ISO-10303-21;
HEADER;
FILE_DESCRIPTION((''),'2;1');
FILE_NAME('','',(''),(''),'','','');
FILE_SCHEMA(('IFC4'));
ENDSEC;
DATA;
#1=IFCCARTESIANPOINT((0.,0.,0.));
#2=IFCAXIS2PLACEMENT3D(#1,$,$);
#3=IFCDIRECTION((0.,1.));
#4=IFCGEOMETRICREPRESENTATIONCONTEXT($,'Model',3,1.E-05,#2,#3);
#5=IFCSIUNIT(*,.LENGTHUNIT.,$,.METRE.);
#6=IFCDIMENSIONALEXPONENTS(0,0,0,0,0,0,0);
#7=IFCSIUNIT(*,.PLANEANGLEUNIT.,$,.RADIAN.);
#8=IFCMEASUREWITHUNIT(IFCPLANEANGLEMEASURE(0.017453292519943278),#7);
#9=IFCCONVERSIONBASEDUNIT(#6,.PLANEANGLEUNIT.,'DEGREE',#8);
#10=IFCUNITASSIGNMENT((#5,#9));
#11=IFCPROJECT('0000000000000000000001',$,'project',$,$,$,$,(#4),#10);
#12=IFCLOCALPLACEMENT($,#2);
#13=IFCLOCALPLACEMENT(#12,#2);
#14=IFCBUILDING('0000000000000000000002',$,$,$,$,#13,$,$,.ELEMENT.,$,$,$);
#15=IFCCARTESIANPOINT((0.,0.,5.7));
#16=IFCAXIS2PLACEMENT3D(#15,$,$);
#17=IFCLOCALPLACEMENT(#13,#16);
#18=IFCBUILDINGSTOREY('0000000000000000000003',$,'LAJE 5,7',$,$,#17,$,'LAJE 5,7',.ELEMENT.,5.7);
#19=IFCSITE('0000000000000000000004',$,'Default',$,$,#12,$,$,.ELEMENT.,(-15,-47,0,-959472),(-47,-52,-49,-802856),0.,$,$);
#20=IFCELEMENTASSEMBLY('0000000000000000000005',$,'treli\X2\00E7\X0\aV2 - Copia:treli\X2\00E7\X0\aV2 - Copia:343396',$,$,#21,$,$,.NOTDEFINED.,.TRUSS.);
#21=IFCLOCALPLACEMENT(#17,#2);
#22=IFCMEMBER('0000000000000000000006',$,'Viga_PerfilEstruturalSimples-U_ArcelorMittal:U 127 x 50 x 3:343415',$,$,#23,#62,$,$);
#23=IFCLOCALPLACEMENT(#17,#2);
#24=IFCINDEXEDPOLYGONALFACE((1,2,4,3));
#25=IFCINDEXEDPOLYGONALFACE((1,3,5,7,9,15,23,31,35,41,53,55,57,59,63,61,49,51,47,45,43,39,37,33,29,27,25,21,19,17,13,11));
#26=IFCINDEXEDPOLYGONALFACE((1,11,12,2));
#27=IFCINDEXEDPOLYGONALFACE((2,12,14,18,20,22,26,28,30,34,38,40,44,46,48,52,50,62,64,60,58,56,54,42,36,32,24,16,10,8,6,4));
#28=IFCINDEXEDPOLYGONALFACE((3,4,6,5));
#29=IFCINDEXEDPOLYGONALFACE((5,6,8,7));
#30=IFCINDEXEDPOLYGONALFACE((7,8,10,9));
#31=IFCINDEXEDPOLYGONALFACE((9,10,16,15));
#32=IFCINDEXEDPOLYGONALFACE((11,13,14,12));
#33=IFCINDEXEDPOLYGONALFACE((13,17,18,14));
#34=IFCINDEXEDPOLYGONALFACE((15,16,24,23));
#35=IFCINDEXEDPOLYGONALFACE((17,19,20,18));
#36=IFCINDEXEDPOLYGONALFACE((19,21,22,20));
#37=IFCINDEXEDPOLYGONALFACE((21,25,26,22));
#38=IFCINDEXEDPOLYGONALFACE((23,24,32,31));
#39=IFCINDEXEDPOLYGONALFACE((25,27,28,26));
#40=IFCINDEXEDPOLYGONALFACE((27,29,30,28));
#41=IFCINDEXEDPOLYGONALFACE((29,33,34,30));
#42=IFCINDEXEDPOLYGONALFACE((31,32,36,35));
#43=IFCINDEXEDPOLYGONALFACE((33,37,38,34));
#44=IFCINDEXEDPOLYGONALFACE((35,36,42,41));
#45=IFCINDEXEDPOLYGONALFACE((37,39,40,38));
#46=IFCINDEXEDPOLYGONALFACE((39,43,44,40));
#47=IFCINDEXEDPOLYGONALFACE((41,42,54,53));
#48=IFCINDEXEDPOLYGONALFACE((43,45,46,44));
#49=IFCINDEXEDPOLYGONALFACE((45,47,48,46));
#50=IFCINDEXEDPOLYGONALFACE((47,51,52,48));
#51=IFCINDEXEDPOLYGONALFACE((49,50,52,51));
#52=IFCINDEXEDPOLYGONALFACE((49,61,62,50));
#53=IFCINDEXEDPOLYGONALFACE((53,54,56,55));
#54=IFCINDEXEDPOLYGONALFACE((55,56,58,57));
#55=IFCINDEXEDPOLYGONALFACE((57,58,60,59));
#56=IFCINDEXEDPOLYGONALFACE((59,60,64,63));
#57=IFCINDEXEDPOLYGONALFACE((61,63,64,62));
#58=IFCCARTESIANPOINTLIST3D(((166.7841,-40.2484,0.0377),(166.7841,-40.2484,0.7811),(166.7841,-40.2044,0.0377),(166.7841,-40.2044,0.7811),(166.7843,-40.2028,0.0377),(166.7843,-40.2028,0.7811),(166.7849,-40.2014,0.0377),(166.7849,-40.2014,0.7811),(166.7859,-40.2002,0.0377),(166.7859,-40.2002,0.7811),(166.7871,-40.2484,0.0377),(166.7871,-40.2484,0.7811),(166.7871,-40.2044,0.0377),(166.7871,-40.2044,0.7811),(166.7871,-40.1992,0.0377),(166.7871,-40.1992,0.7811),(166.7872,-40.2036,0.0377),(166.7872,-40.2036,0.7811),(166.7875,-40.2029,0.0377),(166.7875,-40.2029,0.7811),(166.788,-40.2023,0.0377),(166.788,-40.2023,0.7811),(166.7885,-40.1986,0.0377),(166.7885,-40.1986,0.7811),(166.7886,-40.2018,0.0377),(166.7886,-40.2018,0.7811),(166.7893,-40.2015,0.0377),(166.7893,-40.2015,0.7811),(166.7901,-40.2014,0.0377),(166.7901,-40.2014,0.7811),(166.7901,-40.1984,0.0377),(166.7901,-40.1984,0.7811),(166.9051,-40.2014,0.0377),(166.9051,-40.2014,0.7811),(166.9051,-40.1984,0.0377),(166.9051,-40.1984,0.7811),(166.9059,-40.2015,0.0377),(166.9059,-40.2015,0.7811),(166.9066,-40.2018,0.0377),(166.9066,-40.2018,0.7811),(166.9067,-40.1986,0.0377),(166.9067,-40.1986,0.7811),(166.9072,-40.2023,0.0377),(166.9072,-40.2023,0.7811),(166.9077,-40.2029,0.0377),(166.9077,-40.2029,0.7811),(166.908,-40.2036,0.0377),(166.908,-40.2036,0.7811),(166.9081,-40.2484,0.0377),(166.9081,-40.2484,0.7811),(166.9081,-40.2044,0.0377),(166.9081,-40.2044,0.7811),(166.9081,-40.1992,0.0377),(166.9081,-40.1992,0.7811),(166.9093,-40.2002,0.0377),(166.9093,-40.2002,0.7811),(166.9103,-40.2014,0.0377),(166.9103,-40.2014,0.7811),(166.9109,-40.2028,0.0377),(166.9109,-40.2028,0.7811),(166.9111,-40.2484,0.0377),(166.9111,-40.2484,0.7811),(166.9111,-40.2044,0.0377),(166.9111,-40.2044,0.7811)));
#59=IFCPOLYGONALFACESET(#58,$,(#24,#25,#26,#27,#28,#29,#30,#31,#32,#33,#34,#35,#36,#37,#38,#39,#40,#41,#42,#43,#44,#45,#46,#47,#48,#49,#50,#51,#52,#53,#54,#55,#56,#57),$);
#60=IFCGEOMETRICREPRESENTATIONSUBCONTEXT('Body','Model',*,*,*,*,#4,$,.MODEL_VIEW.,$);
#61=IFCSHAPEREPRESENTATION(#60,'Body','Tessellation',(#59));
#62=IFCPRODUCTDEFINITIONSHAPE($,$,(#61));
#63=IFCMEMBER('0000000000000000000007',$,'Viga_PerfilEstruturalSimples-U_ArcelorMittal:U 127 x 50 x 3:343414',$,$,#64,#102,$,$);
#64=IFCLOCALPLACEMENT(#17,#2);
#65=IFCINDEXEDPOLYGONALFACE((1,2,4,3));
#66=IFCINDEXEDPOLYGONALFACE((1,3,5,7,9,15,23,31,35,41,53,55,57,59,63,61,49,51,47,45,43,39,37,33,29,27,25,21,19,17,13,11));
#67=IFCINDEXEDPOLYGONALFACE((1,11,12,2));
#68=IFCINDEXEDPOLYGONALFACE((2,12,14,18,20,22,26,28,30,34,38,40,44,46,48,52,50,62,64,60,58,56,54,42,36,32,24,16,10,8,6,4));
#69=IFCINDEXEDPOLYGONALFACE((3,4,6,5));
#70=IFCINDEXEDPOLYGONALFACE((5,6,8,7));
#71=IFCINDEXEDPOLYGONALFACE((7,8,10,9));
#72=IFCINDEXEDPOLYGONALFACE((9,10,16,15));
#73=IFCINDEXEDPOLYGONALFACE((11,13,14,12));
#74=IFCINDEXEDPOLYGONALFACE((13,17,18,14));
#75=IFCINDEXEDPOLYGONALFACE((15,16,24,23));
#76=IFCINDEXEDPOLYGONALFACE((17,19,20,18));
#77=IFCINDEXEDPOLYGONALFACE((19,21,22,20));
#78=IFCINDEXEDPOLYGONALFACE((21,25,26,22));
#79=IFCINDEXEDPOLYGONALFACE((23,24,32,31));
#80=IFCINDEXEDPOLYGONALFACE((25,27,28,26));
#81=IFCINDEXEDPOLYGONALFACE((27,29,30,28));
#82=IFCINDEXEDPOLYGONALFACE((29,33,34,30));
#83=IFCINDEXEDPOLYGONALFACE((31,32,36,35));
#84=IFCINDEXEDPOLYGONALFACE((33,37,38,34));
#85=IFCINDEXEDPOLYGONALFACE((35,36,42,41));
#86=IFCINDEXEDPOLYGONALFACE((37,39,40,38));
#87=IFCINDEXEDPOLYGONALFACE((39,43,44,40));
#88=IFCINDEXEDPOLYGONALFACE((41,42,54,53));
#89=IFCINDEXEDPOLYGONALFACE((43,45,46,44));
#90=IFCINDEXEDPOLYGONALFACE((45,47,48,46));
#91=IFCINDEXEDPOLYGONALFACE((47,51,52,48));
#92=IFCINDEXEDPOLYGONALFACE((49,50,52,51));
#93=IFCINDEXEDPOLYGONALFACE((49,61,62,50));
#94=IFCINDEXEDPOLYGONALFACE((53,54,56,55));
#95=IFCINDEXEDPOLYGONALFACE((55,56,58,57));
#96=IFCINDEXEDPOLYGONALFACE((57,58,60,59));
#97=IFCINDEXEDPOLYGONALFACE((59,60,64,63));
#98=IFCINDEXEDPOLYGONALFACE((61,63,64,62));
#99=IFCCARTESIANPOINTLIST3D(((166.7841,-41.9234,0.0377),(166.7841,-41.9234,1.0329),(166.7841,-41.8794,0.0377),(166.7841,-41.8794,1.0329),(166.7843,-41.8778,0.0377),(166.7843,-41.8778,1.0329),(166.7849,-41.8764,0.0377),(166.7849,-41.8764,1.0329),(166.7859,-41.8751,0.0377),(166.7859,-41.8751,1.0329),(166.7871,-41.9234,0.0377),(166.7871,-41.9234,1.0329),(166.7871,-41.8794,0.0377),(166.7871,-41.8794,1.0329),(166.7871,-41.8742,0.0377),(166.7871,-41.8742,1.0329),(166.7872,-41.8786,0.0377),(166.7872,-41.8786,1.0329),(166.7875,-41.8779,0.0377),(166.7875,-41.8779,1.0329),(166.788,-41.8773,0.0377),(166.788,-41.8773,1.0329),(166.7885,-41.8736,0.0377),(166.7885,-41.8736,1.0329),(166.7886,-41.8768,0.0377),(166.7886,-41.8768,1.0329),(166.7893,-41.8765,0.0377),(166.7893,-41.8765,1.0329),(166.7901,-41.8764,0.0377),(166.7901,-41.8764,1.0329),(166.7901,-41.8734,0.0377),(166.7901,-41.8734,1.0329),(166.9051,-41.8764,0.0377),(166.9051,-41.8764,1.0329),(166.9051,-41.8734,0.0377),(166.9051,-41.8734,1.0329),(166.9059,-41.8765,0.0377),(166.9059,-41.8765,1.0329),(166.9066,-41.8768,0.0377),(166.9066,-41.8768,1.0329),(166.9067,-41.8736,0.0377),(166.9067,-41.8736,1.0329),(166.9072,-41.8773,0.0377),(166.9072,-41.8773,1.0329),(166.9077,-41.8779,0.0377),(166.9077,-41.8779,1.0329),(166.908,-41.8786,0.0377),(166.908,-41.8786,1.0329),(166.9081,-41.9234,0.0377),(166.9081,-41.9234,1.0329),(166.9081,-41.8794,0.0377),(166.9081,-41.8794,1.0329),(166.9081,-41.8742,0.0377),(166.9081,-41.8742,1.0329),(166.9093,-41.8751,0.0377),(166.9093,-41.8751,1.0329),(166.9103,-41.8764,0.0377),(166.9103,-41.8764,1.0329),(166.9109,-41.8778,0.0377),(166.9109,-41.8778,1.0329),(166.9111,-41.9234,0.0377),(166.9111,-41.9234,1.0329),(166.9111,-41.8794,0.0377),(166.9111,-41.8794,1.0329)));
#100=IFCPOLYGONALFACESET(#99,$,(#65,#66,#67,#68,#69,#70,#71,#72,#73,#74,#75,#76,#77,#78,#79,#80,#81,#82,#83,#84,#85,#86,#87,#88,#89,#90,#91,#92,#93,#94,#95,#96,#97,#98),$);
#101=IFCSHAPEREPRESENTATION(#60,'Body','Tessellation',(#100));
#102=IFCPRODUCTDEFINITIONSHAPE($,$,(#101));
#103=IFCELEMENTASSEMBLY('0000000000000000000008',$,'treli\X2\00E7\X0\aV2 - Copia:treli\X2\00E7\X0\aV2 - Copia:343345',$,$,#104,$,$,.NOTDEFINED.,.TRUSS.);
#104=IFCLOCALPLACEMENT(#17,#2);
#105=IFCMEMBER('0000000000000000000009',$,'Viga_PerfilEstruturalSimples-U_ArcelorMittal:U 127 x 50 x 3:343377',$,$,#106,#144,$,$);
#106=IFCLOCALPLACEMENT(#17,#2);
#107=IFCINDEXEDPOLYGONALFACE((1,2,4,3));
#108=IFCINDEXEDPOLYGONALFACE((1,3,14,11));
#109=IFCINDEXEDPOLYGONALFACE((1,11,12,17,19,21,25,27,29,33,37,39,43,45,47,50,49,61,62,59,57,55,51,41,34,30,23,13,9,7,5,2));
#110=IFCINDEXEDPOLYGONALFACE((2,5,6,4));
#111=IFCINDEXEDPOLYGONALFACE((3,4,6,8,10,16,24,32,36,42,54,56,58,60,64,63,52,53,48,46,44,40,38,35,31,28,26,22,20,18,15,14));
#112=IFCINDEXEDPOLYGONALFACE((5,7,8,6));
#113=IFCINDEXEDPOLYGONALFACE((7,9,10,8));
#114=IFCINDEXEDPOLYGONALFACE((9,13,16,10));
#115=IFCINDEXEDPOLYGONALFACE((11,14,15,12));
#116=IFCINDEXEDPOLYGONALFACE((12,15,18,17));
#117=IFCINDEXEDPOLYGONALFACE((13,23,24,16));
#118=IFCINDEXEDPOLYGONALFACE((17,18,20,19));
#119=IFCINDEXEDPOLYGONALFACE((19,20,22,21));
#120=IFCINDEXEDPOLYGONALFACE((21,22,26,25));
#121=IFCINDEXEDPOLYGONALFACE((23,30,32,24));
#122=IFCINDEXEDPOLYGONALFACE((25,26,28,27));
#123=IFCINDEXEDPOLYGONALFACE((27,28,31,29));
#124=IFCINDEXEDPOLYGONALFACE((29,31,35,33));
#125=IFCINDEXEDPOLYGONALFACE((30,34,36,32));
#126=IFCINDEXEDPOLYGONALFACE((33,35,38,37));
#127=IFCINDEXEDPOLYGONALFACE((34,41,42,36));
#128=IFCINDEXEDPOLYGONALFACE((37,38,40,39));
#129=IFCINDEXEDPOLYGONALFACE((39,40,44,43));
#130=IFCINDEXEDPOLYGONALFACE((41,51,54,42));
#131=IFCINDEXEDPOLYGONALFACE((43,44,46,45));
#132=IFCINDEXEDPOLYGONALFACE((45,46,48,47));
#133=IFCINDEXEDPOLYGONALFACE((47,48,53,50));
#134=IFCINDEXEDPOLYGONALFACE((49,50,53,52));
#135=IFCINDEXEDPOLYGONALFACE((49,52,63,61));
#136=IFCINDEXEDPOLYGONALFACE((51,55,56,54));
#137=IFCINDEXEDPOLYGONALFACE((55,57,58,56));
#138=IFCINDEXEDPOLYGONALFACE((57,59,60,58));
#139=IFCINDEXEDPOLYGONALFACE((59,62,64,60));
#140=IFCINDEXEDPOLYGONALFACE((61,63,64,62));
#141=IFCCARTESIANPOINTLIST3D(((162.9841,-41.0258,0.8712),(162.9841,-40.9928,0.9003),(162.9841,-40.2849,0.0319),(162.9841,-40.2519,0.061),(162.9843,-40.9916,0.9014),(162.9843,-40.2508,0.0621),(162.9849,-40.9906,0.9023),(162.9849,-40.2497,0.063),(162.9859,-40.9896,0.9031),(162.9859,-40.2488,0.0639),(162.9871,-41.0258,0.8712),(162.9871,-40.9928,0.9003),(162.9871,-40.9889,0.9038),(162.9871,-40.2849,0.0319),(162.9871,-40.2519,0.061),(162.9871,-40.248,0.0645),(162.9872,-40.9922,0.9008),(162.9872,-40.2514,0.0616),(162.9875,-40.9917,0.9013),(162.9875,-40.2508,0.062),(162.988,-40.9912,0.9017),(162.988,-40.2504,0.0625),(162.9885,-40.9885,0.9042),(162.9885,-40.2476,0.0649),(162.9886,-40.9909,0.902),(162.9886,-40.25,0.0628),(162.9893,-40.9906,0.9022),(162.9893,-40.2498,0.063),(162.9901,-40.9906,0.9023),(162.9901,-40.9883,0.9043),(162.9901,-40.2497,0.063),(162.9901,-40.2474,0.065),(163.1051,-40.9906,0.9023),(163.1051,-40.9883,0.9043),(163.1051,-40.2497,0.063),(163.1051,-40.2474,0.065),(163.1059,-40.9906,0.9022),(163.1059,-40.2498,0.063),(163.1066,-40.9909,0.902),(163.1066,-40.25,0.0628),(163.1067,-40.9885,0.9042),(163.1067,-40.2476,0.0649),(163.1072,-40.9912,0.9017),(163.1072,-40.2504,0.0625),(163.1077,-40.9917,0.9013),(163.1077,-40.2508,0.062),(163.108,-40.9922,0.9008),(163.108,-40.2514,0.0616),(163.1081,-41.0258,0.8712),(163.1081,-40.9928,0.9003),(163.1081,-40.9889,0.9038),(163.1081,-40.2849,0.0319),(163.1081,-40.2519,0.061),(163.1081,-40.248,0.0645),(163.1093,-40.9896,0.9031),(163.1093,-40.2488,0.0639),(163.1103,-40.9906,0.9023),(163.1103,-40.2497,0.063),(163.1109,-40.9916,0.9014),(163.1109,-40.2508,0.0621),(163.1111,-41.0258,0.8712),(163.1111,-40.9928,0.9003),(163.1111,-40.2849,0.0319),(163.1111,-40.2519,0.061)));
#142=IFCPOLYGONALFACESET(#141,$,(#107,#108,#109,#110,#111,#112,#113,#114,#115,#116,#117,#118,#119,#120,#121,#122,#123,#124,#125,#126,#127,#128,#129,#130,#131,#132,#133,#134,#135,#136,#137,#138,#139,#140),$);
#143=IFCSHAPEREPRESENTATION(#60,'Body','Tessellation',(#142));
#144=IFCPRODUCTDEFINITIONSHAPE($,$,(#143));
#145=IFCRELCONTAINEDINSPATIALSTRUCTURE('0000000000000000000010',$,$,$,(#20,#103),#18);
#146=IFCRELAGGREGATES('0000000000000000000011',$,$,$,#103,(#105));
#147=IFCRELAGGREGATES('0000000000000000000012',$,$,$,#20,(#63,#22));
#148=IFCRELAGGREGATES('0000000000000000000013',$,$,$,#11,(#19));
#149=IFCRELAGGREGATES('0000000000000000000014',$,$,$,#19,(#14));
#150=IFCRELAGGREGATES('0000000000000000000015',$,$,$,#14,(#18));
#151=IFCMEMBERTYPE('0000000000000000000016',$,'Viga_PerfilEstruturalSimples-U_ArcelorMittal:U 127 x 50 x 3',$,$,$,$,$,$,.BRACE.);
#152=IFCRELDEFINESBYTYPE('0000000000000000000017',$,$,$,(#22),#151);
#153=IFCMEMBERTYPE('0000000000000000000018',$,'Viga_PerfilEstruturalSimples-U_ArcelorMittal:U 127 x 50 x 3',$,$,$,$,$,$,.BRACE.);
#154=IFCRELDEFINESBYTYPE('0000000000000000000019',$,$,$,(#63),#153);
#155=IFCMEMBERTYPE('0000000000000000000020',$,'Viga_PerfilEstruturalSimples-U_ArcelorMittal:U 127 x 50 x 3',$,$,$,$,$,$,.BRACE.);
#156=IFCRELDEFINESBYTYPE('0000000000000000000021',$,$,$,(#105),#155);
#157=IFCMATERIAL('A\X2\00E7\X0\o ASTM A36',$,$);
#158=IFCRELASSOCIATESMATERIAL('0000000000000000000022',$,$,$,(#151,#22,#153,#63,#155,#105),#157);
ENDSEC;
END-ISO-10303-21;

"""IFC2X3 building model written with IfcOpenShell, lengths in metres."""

from ifc_helpers import new_model, entity, si_unit, converted_unit, direction, frame, frame_2d, origin, place, context, subcontext, project, spatial, polyline, circle_curve, parameter, trimmed, segment, composite_curve, outline, extrude, source, transform, mapped, material, type_object, type_shapes, element, aggregate, save


model = new_model("IFC2X3")

# Units and contexts
model_context = context("Model", 3, precision=1e-05, world=origin(), true_north=direction((0.0, 1.0)))
body_context = subcontext(model_context, "Body", "Model", "MODEL_VIEW")
ifc_project = project(units=[si_unit("LENGTHUNIT", "METRE"), converted_unit("PLANEANGLEUNIT", "DEGREE", entity("IfcPlaneAngleMeasure", 0.017453292519943278), si_unit("PLANEANGLEUNIT", "RADIAN"), dimensions=[0, 0, 0, 0, 0, 0, 0])], contexts=[model_context])

# Site, building, storey
site_placement = place(None, origin())
site = spatial("IfcSite", under=ifc_project, at=site_placement, Name="Default", CompositionType="ELEMENT", RefLatitude=(-15, -47, 0, -959472), RefLongitude=(-47, -52, -49, -802856), RefElevation=0.0)
building_placement = place(site_placement, origin())
building = spatial("IfcBuilding", under=site, at=building_placement, CompositionType="ELEMENT")
storey_placement = place(building_placement, frame((0.0, 0.0, 5.7)))
storey = spatial("IfcBuildingStorey", under=building, at=storey_placement, Name="LAJE 5,7", LongName="LAJE 5,7", CompositionType="ELEMENT", Elevation=5.7)

# Element assembly
assembly_1_placement = place(storey_placement, origin())
assembly_1 = element("IfcElementAssembly", 1, at=assembly_1_placement, inside=storey, Name="treliçaV2 - Copia:treliçaV2 - Copia:343396", AssemblyPlace="NOTDEFINED", PredefinedType="TRUSS")
ifc_material = material(Name="Aço ASTM A36")

# Members
member_type_1 = type_object("IfcMemberType", Name="Viga_PerfilEstruturalSimples-U_ArcelorMittal:U 127 x 50 x 3", PredefinedType="BRACE", material=ifc_material)
shared_shape_1 = source(origin(), body_context, "Body", "SweptSolid", [
    extrude(outline(composite_curve([segment(polyline([(-0.0575, -0.0192), (0.0575, -0.0192)]), True, "CONTINUOUS"), segment(trimmed(circle_curve(frame_2d((0.0575, -0.0132), x_axis=(0.0, 1.0)), 0.006), [parameter(180.0)], [parameter(270.0)], True, "PARAMETER"), True, "CONTINUOUS"), segment(polyline([(0.0635, -0.0132), (0.0635, 0.0308)]), True, "CONTINUOUS"), segment(polyline([(0.0635, 0.0308), (0.0605, 0.0308)]), True, "CONTINUOUS"), segment(polyline([(0.0605, 0.0308), (0.0605, -0.0132)]), True, "CONTINUOUS"), segment(trimmed(circle_curve(frame_2d((0.0575, -0.0132), x_axis=(0.0, 1.0)), 0.003), [parameter(180.0)], [parameter(270.0)], True, "PARAMETER"), False, "CONTINUOUS"), segment(polyline([(0.0575, -0.0162), (-0.0575, -0.0162)]), True, "CONTINUOUS"), segment(trimmed(circle_curve(frame_2d((-0.0575, -0.0132), x_axis=(0.0, 1.0)), 0.003), [parameter(90.0)], [parameter(180.0)], True, "PARAMETER"), False, "CONTINUOUS"), segment(polyline([(-0.0605, -0.0132), (-0.0605, 0.0308)]), True, "CONTINUOUS"), segment(polyline([(-0.0605, 0.0308), (-0.0635, 0.0308)]), True, "CONTINUOUS"), segment(polyline([(-0.0635, 0.0308), (-0.0635, -0.0132)]), True, "CONTINUOUS"), segment(trimmed(circle_curve(frame_2d((-0.0575, -0.0132), x_axis=(0.0, 1.0)), 0.006), [parameter(90.0)], [parameter(180.0)], True, "PARAMETER"), True, "CONTINUOUS")], self_intersect=False)), frame((-0.3737, -0.0058, 0.0), z_axis=(1.0, 0.0, 0.0), x_axis=(0.0, 0.0, -1.0)), (0.0, 0.0, 1.0), 0.7434),
])
type_shapes(member_type_1, [shared_shape_1])
member_1_placement = place(assembly_1_placement, frame((166.8476, -40.2234, 0.4114), z_axis=(1.0, 0.0, 0.0), x_axis=(0.0, 0.0, 1.0)))
member_1 = element("IfcMember", 2, at=member_1_placement, type_object=member_type_1, material=ifc_material, Name="Viga_PerfilEstruturalSimples-U_ArcelorMittal:U 127 x 50 x 3:343415", context=body_context, shape_type="MappedRepresentation", body=[
    mapped(shared_shape_1, transform((0.0, 0.0, 0.0), scale=1.0)),
])
member_type_2 = type_object("IfcMemberType", Name="Viga_PerfilEstruturalSimples-U_ArcelorMittal:U 127 x 50 x 3", PredefinedType="BRACE", material=ifc_material)
shared_shape_2 = source(origin(), body_context, "Body", "SweptSolid", [
    extrude(outline(composite_curve([segment(polyline([(-0.0575, -0.0192), (0.0575, -0.0192)]), True, "CONTINUOUS"), segment(trimmed(circle_curve(frame_2d((0.0575, -0.0132), x_axis=(0.0, 1.0)), 0.006), [parameter(180.0)], [parameter(270.0)], True, "PARAMETER"), True, "CONTINUOUS"), segment(polyline([(0.0635, -0.0132), (0.0635, 0.0308)]), True, "CONTINUOUS"), segment(polyline([(0.0635, 0.0308), (0.0605, 0.0308)]), True, "CONTINUOUS"), segment(polyline([(0.0605, 0.0308), (0.0605, -0.0132)]), True, "CONTINUOUS"), segment(trimmed(circle_curve(frame_2d((0.0575, -0.0132), x_axis=(0.0, 1.0)), 0.003), [parameter(180.0)], [parameter(270.0)], True, "PARAMETER"), False, "CONTINUOUS"), segment(polyline([(0.0575, -0.0162), (-0.0575, -0.0162)]), True, "CONTINUOUS"), segment(trimmed(circle_curve(frame_2d((-0.0575, -0.0132), x_axis=(0.0, 1.0)), 0.003), [parameter(90.0)], [parameter(180.0)], True, "PARAMETER"), False, "CONTINUOUS"), segment(polyline([(-0.0605, -0.0132), (-0.0605, 0.0308)]), True, "CONTINUOUS"), segment(polyline([(-0.0605, 0.0308), (-0.0635, 0.0308)]), True, "CONTINUOUS"), segment(polyline([(-0.0635, 0.0308), (-0.0635, -0.0132)]), True, "CONTINUOUS"), segment(trimmed(circle_curve(frame_2d((-0.0575, -0.0132), x_axis=(0.0, 1.0)), 0.006), [parameter(90.0)], [parameter(180.0)], True, "PARAMETER"), True, "CONTINUOUS")], self_intersect=False)), frame((-0.4996, -0.0058, 0.0), z_axis=(1.0, 0.0, 0.0), x_axis=(0.0, 0.0, -1.0)), (0.0, 0.0, 1.0), 0.9952),
])
type_shapes(member_type_2, [shared_shape_2])
member_2_placement = place(assembly_1_placement, frame((166.8476, -41.8984, 0.5373), z_axis=(1.0, 0.0, 0.0), x_axis=(0.0, 0.0, 1.0)))
member_2 = element("IfcMember", 3, at=member_2_placement, type_object=member_type_2, material=ifc_material, Name="Viga_PerfilEstruturalSimples-U_ArcelorMittal:U 127 x 50 x 3:343414", context=body_context, shape_type="MappedRepresentation", body=[
    mapped(shared_shape_2, transform((0.0, 0.0, 0.0), scale=1.0)),
])

# Element assembly
assembly_2_placement = place(storey_placement, origin())
assembly_2 = element("IfcElementAssembly", 4, at=assembly_2_placement, inside=storey, Name="treliçaV2 - Copia:treliçaV2 - Copia:343345", AssemblyPlace="NOTDEFINED", PredefinedType="TRUSS")

# Member
member_type_3 = type_object("IfcMemberType", Name="Viga_PerfilEstruturalSimples-U_ArcelorMittal:U 127 x 50 x 3", PredefinedType="BRACE", material=ifc_material)
shared_shape_3 = source(origin(), body_context, "Body", "SweptSolid", [
    extrude(outline(composite_curve([segment(polyline([(-0.0575, -0.0192), (0.0575, -0.0192)]), True, "CONTINUOUS"), segment(trimmed(circle_curve(frame_2d((0.0575, -0.0132), x_axis=(0.0, 1.0)), 0.006), [parameter(180.0)], [parameter(270.0)], True, "PARAMETER"), True, "CONTINUOUS"), segment(polyline([(0.0635, -0.0132), (0.0635, 0.0308)]), True, "CONTINUOUS"), segment(polyline([(0.0635, 0.0308), (0.0605, 0.0308)]), True, "CONTINUOUS"), segment(polyline([(0.0605, 0.0308), (0.0605, -0.0132)]), True, "CONTINUOUS"), segment(trimmed(circle_curve(frame_2d((0.0575, -0.0132), x_axis=(0.0, 1.0)), 0.003), [parameter(180.0)], [parameter(270.0)], True, "PARAMETER"), False, "CONTINUOUS"), segment(polyline([(0.0575, -0.0162), (-0.0575, -0.0162)]), True, "CONTINUOUS"), segment(trimmed(circle_curve(frame_2d((-0.0575, -0.0132), x_axis=(0.0, 1.0)), 0.003), [parameter(90.0)], [parameter(180.0)], True, "PARAMETER"), False, "CONTINUOUS"), segment(polyline([(-0.0605, -0.0132), (-0.0605, 0.0308)]), True, "CONTINUOUS"), segment(polyline([(-0.0605, 0.0308), (-0.0635, 0.0308)]), True, "CONTINUOUS"), segment(polyline([(-0.0635, 0.0308), (-0.0635, -0.0132)]), True, "CONTINUOUS"), segment(trimmed(circle_curve(frame_2d((-0.0575, -0.0132), x_axis=(0.0, 1.0)), 0.006), [parameter(90.0)], [parameter(180.0)], True, "PARAMETER"), True, "CONTINUOUS")], self_intersect=False)), frame((-0.5514, -0.0058, 0.0), z_axis=(1.0, 0.0, 0.0), x_axis=(0.0, 0.0, -1.0)), (0.0, 0.0, 1.0), 1.1195),
])
type_shapes(member_type_3, [shared_shape_3])
member_3_placement = place(assembly_2_placement, frame((163.0476, -40.6421, 0.4744), z_axis=(-1.0, 0.0, 0.0), x_axis=(0.0, 0.661783, -0.749695)))
member_3 = element("IfcMember", 5, at=member_3_placement, type_object=member_type_3, material=ifc_material, Name="Viga_PerfilEstruturalSimples-U_ArcelorMittal:U 127 x 50 x 3:343377", context=body_context, shape_type="MappedRepresentation", body=[
    mapped(shared_shape_3, transform((0.0, 0.0, 0.0), scale=1.0)),
])
aggregate(assembly_2, [member_3])
aggregate(assembly_1, [member_2, member_1])

save(model, "model.ifc")
